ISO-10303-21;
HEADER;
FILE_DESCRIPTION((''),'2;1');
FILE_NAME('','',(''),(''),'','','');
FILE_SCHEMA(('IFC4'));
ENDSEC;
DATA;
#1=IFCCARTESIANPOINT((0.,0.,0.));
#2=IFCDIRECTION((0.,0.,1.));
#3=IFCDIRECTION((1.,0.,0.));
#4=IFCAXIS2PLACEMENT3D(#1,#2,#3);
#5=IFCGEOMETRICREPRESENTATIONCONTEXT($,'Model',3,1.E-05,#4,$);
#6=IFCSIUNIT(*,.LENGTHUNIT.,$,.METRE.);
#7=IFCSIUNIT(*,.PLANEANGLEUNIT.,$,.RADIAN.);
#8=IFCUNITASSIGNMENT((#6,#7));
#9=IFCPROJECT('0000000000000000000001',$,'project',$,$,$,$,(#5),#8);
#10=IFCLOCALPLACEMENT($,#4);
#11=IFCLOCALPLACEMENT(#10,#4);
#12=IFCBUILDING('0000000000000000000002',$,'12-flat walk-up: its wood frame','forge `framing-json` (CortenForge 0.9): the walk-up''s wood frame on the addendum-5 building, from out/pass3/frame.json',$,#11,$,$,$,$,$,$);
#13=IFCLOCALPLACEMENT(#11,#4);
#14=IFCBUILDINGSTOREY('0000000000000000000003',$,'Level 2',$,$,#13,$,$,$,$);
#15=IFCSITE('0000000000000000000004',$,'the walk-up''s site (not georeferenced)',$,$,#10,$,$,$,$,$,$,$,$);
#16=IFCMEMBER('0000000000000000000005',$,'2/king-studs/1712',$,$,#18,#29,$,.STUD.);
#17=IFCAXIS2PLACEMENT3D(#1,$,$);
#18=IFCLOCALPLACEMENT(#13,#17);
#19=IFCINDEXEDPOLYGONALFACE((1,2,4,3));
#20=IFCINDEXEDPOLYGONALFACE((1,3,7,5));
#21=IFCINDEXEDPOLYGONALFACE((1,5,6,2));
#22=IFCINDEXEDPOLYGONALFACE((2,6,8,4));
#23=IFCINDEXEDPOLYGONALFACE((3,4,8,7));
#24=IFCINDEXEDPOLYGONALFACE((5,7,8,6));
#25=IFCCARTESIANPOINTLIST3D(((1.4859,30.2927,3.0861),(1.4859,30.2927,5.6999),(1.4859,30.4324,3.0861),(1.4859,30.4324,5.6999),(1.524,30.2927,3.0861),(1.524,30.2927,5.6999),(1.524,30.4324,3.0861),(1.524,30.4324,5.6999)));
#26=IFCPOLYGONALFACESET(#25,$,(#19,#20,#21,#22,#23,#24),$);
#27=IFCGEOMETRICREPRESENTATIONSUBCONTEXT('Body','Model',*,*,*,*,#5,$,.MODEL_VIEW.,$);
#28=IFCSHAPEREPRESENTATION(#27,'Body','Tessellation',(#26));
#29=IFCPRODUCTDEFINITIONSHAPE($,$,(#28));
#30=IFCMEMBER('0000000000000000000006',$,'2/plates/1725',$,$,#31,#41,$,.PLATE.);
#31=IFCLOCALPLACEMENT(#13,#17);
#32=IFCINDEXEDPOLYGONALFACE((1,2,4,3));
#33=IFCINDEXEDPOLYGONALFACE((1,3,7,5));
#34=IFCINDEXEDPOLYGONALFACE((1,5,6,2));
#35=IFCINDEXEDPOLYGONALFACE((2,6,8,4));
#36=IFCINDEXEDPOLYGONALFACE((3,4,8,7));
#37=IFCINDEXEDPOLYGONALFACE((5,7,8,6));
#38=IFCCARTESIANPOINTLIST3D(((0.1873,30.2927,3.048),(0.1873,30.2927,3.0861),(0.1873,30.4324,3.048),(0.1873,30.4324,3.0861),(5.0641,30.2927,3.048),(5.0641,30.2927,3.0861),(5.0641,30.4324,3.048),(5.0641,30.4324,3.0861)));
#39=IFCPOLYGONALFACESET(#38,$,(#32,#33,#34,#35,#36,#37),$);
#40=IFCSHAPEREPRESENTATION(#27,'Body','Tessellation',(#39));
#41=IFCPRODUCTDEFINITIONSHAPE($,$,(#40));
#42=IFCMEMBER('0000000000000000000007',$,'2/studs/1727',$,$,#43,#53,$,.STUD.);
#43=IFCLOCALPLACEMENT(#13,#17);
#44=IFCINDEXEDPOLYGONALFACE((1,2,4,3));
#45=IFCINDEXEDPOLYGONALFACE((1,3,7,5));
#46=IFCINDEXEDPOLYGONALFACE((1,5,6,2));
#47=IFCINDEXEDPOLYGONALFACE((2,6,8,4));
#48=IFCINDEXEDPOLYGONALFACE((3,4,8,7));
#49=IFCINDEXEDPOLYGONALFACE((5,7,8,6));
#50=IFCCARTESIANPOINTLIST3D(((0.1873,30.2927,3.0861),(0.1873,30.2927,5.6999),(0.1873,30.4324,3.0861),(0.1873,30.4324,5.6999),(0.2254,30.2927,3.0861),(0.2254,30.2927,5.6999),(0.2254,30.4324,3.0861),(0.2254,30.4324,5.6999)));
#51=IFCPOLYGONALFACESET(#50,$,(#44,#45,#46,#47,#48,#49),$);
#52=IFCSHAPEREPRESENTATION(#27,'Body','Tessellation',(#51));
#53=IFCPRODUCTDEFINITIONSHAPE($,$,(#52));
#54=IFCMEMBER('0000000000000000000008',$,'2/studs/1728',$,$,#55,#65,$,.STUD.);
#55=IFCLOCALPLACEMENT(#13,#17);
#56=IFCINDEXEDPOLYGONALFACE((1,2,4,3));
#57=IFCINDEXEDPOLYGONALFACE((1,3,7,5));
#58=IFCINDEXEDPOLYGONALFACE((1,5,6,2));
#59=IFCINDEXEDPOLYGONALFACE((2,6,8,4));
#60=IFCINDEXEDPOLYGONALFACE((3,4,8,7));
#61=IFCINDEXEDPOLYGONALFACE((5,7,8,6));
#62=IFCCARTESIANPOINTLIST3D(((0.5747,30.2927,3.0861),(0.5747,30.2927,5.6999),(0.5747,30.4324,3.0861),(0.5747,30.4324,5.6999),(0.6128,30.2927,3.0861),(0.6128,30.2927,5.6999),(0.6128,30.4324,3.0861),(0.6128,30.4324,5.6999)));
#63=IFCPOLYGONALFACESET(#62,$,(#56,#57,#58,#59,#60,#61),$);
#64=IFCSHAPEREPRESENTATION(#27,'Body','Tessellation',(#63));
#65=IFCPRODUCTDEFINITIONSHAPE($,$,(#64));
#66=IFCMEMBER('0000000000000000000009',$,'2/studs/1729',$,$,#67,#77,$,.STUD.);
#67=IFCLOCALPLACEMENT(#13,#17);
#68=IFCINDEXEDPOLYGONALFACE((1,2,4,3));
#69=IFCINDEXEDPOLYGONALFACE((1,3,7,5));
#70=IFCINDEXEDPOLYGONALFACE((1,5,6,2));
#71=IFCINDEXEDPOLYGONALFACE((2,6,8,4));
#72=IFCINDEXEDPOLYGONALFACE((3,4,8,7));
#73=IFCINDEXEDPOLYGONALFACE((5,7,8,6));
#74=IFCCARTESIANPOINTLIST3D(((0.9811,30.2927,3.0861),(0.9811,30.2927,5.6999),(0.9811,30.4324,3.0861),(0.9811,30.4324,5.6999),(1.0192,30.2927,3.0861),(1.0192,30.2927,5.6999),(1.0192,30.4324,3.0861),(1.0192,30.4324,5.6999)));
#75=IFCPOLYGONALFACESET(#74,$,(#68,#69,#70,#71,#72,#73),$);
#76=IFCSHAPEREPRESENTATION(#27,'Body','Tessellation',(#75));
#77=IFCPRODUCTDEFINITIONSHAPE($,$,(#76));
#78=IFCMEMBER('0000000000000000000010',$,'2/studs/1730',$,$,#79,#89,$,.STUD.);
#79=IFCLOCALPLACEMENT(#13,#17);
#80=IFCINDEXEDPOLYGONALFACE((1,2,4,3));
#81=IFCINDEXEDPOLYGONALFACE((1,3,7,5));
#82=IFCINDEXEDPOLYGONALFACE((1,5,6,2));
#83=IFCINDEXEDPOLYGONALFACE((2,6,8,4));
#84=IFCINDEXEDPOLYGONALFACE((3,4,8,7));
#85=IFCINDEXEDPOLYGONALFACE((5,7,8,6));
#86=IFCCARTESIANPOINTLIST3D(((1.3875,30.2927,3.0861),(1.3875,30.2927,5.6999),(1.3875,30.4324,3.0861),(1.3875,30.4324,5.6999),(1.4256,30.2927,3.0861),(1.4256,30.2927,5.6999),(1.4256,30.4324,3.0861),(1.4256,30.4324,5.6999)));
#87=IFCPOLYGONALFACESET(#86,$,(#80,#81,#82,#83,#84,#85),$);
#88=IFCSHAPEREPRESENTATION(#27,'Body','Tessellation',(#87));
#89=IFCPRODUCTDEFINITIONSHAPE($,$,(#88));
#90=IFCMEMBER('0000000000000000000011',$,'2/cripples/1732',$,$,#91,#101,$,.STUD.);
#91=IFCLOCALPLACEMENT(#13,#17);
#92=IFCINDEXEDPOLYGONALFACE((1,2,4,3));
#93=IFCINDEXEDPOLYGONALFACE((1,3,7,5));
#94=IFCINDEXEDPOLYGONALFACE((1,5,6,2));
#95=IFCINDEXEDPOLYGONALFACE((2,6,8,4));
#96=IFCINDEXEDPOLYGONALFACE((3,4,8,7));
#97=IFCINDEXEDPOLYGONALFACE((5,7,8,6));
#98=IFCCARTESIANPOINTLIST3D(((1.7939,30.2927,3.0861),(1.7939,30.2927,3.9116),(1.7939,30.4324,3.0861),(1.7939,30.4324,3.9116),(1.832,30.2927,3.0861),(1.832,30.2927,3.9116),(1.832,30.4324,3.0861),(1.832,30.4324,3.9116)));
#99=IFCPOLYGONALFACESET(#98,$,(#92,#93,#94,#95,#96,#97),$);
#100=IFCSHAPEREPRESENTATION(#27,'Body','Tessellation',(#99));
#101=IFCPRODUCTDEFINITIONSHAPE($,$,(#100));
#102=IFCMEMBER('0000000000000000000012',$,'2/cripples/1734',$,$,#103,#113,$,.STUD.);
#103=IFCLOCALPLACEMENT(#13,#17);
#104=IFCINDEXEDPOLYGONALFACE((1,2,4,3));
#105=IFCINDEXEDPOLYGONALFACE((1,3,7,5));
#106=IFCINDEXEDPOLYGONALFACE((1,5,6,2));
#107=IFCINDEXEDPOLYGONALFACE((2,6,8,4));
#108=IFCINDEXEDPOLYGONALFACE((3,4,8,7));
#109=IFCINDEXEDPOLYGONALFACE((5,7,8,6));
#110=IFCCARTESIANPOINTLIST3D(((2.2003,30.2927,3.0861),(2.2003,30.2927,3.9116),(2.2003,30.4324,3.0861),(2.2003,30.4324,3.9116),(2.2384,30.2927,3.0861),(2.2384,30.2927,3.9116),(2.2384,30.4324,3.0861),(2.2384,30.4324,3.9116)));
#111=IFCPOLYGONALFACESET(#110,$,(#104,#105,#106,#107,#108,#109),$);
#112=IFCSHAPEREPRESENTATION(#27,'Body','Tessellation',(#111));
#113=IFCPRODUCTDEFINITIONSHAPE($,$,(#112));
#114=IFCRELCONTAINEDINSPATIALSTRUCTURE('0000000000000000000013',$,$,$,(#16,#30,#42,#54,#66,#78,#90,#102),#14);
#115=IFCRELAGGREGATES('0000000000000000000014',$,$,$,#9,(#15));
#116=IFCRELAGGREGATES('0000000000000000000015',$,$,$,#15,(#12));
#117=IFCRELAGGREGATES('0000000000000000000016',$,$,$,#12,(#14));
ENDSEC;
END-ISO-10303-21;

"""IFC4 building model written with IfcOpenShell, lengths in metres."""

from ifc_helpers import new_model, si_unit, frame, frame_2d, origin, origin_with_axes, place, context, subcontext, project, spatial, rectangle, extrude, element, save


model = new_model("IFC4")

# Units and contexts
model_context = context("Model", 3, precision=1e-05, world=origin_with_axes())
body_context = subcontext(model_context, "Body", "Model", "MODEL_VIEW")
ifc_project = project(units=[si_unit("LENGTHUNIT", "METRE"), si_unit("PLANEANGLEUNIT", "RADIAN")], contexts=[model_context])

# Site, building, storey
site_placement = place(None, origin_with_axes())
site = spatial("IfcSite", under=ifc_project, at=site_placement, Name="the walk-up's site (not georeferenced)")
building_placement = place(site_placement, origin_with_axes())
building = spatial("IfcBuilding", under=site, at=building_placement, Name="12-flat walk-up: its wood frame", Description="forge `framing-json` (CortenForge 0.9): the walk-up's wood frame on the addendum-5 building, from out/pass3/frame.json")
storey_placement = place(building_placement, origin_with_axes())
storey = spatial("IfcBuildingStorey", under=building, at=storey_placement, Name="Level 2")

# Members
member_1_placement = place(storey_placement, frame((1.4859, 30.2927, 3.0861), z_axis=(0.0, 0.0, 1.0), x_axis=(1.0, 0.0, 0.0)))
element("IfcMember", 1, at=member_1_placement, inside=storey, Name="2/king-studs/1712", PredefinedType="STUD", context=body_context, shape_type="SweptSolid", body=[
    extrude(rectangle(XDim=0.0381, YDim=0.1397, at=frame_2d((0.0191, 0.0699))), origin(), (0.0, 0.0, 1.0), 2.6138),
])
member_2_placement = place(storey_placement, frame((0.1873, 30.2927, 3.048), z_axis=(0.0, 0.0, 1.0), x_axis=(1.0, 0.0, 0.0)))
element("IfcMember", 2, at=member_2_placement, inside=storey, Name="2/plates/1725", PredefinedType="PLATE", context=body_context, shape_type="SweptSolid", body=[
    extrude(rectangle(XDim=4.8768, YDim=0.1397, at=frame_2d((2.4384, 0.0699))), origin(), (0.0, 0.0, 1.0), 0.0381),
])
member_3_placement = place(storey_placement, frame((0.1873, 30.2927, 3.0861), z_axis=(0.0, 0.0, 1.0), x_axis=(1.0, 0.0, 0.0)))
element("IfcMember", 3, at=member_3_placement, inside=storey, Name="2/studs/1727", PredefinedType="STUD", context=body_context, shape_type="SweptSolid", body=[
    extrude(rectangle(XDim=0.0381, YDim=0.1397, at=frame_2d((0.019, 0.0699))), origin(), (0.0, 0.0, 1.0), 2.6138),
])
for number, where, z_axis, x_axis, name in (
    (4, (0.5747, 30.2927, 3.0861), (0.0, 0.0, 1.0), (1.0, 0.0, 0.0), "2/studs/1728"),
    (5, (0.9811, 30.2927, 3.0861), (0.0, 0.0, 1.0), (1.0, 0.0, 0.0), "2/studs/1729"),
):
    element("IfcMember", number, at=place(storey_placement, frame(where, z_axis=z_axis, x_axis=x_axis)), inside=storey, Name=name, PredefinedType="STUD", context=body_context, shape_type="SweptSolid", body=[
        extrude(rectangle(XDim=0.0381, YDim=0.1397, at=frame_2d((0.019, 0.0699))), origin(), (0.0, 0.0, 1.0), 2.6138),
    ])
member_4_placement = place(storey_placement, frame((1.3875, 30.2927, 3.0861), z_axis=(0.0, 0.0, 1.0), x_axis=(1.0, 0.0, 0.0)))
element("IfcMember", 6, at=member_4_placement, inside=storey, Name="2/studs/1730", PredefinedType="STUD", context=body_context, shape_type="SweptSolid", body=[
    extrude(rectangle(XDim=0.0381, YDim=0.1397, at=frame_2d((0.0191, 0.0699))), origin(), (0.0, 0.0, 1.0), 2.6138),
])
member_5_placement = place(storey_placement, frame((1.7939, 30.2927, 3.0861), z_axis=(0.0, 0.0, 1.0), x_axis=(1.0, 0.0, 0.0)))
element("IfcMember", 7, at=member_5_placement, inside=storey, Name="2/cripples/1732", PredefinedType="STUD", context=body_context, shape_type="SweptSolid", body=[
    extrude(rectangle(XDim=0.0381, YDim=0.1397, at=frame_2d((0.019, 0.0699))), origin(), (0.0, 0.0, 1.0), 0.8255),
])
member_6_placement = place(storey_placement, frame((2.2003, 30.2927, 3.0861), z_axis=(0.0, 0.0, 1.0), x_axis=(1.0, 0.0, 0.0)))
element("IfcMember", 8, at=member_6_placement, inside=storey, Name="2/cripples/1734", PredefinedType="STUD", context=body_context, shape_type="SweptSolid", body=[
    extrude(rectangle(XDim=0.0381, YDim=0.1397, at=frame_2d((0.0191, 0.0699))), origin(), (0.0, 0.0, 1.0), 0.8255),
])

save(model, "model.ifc")
